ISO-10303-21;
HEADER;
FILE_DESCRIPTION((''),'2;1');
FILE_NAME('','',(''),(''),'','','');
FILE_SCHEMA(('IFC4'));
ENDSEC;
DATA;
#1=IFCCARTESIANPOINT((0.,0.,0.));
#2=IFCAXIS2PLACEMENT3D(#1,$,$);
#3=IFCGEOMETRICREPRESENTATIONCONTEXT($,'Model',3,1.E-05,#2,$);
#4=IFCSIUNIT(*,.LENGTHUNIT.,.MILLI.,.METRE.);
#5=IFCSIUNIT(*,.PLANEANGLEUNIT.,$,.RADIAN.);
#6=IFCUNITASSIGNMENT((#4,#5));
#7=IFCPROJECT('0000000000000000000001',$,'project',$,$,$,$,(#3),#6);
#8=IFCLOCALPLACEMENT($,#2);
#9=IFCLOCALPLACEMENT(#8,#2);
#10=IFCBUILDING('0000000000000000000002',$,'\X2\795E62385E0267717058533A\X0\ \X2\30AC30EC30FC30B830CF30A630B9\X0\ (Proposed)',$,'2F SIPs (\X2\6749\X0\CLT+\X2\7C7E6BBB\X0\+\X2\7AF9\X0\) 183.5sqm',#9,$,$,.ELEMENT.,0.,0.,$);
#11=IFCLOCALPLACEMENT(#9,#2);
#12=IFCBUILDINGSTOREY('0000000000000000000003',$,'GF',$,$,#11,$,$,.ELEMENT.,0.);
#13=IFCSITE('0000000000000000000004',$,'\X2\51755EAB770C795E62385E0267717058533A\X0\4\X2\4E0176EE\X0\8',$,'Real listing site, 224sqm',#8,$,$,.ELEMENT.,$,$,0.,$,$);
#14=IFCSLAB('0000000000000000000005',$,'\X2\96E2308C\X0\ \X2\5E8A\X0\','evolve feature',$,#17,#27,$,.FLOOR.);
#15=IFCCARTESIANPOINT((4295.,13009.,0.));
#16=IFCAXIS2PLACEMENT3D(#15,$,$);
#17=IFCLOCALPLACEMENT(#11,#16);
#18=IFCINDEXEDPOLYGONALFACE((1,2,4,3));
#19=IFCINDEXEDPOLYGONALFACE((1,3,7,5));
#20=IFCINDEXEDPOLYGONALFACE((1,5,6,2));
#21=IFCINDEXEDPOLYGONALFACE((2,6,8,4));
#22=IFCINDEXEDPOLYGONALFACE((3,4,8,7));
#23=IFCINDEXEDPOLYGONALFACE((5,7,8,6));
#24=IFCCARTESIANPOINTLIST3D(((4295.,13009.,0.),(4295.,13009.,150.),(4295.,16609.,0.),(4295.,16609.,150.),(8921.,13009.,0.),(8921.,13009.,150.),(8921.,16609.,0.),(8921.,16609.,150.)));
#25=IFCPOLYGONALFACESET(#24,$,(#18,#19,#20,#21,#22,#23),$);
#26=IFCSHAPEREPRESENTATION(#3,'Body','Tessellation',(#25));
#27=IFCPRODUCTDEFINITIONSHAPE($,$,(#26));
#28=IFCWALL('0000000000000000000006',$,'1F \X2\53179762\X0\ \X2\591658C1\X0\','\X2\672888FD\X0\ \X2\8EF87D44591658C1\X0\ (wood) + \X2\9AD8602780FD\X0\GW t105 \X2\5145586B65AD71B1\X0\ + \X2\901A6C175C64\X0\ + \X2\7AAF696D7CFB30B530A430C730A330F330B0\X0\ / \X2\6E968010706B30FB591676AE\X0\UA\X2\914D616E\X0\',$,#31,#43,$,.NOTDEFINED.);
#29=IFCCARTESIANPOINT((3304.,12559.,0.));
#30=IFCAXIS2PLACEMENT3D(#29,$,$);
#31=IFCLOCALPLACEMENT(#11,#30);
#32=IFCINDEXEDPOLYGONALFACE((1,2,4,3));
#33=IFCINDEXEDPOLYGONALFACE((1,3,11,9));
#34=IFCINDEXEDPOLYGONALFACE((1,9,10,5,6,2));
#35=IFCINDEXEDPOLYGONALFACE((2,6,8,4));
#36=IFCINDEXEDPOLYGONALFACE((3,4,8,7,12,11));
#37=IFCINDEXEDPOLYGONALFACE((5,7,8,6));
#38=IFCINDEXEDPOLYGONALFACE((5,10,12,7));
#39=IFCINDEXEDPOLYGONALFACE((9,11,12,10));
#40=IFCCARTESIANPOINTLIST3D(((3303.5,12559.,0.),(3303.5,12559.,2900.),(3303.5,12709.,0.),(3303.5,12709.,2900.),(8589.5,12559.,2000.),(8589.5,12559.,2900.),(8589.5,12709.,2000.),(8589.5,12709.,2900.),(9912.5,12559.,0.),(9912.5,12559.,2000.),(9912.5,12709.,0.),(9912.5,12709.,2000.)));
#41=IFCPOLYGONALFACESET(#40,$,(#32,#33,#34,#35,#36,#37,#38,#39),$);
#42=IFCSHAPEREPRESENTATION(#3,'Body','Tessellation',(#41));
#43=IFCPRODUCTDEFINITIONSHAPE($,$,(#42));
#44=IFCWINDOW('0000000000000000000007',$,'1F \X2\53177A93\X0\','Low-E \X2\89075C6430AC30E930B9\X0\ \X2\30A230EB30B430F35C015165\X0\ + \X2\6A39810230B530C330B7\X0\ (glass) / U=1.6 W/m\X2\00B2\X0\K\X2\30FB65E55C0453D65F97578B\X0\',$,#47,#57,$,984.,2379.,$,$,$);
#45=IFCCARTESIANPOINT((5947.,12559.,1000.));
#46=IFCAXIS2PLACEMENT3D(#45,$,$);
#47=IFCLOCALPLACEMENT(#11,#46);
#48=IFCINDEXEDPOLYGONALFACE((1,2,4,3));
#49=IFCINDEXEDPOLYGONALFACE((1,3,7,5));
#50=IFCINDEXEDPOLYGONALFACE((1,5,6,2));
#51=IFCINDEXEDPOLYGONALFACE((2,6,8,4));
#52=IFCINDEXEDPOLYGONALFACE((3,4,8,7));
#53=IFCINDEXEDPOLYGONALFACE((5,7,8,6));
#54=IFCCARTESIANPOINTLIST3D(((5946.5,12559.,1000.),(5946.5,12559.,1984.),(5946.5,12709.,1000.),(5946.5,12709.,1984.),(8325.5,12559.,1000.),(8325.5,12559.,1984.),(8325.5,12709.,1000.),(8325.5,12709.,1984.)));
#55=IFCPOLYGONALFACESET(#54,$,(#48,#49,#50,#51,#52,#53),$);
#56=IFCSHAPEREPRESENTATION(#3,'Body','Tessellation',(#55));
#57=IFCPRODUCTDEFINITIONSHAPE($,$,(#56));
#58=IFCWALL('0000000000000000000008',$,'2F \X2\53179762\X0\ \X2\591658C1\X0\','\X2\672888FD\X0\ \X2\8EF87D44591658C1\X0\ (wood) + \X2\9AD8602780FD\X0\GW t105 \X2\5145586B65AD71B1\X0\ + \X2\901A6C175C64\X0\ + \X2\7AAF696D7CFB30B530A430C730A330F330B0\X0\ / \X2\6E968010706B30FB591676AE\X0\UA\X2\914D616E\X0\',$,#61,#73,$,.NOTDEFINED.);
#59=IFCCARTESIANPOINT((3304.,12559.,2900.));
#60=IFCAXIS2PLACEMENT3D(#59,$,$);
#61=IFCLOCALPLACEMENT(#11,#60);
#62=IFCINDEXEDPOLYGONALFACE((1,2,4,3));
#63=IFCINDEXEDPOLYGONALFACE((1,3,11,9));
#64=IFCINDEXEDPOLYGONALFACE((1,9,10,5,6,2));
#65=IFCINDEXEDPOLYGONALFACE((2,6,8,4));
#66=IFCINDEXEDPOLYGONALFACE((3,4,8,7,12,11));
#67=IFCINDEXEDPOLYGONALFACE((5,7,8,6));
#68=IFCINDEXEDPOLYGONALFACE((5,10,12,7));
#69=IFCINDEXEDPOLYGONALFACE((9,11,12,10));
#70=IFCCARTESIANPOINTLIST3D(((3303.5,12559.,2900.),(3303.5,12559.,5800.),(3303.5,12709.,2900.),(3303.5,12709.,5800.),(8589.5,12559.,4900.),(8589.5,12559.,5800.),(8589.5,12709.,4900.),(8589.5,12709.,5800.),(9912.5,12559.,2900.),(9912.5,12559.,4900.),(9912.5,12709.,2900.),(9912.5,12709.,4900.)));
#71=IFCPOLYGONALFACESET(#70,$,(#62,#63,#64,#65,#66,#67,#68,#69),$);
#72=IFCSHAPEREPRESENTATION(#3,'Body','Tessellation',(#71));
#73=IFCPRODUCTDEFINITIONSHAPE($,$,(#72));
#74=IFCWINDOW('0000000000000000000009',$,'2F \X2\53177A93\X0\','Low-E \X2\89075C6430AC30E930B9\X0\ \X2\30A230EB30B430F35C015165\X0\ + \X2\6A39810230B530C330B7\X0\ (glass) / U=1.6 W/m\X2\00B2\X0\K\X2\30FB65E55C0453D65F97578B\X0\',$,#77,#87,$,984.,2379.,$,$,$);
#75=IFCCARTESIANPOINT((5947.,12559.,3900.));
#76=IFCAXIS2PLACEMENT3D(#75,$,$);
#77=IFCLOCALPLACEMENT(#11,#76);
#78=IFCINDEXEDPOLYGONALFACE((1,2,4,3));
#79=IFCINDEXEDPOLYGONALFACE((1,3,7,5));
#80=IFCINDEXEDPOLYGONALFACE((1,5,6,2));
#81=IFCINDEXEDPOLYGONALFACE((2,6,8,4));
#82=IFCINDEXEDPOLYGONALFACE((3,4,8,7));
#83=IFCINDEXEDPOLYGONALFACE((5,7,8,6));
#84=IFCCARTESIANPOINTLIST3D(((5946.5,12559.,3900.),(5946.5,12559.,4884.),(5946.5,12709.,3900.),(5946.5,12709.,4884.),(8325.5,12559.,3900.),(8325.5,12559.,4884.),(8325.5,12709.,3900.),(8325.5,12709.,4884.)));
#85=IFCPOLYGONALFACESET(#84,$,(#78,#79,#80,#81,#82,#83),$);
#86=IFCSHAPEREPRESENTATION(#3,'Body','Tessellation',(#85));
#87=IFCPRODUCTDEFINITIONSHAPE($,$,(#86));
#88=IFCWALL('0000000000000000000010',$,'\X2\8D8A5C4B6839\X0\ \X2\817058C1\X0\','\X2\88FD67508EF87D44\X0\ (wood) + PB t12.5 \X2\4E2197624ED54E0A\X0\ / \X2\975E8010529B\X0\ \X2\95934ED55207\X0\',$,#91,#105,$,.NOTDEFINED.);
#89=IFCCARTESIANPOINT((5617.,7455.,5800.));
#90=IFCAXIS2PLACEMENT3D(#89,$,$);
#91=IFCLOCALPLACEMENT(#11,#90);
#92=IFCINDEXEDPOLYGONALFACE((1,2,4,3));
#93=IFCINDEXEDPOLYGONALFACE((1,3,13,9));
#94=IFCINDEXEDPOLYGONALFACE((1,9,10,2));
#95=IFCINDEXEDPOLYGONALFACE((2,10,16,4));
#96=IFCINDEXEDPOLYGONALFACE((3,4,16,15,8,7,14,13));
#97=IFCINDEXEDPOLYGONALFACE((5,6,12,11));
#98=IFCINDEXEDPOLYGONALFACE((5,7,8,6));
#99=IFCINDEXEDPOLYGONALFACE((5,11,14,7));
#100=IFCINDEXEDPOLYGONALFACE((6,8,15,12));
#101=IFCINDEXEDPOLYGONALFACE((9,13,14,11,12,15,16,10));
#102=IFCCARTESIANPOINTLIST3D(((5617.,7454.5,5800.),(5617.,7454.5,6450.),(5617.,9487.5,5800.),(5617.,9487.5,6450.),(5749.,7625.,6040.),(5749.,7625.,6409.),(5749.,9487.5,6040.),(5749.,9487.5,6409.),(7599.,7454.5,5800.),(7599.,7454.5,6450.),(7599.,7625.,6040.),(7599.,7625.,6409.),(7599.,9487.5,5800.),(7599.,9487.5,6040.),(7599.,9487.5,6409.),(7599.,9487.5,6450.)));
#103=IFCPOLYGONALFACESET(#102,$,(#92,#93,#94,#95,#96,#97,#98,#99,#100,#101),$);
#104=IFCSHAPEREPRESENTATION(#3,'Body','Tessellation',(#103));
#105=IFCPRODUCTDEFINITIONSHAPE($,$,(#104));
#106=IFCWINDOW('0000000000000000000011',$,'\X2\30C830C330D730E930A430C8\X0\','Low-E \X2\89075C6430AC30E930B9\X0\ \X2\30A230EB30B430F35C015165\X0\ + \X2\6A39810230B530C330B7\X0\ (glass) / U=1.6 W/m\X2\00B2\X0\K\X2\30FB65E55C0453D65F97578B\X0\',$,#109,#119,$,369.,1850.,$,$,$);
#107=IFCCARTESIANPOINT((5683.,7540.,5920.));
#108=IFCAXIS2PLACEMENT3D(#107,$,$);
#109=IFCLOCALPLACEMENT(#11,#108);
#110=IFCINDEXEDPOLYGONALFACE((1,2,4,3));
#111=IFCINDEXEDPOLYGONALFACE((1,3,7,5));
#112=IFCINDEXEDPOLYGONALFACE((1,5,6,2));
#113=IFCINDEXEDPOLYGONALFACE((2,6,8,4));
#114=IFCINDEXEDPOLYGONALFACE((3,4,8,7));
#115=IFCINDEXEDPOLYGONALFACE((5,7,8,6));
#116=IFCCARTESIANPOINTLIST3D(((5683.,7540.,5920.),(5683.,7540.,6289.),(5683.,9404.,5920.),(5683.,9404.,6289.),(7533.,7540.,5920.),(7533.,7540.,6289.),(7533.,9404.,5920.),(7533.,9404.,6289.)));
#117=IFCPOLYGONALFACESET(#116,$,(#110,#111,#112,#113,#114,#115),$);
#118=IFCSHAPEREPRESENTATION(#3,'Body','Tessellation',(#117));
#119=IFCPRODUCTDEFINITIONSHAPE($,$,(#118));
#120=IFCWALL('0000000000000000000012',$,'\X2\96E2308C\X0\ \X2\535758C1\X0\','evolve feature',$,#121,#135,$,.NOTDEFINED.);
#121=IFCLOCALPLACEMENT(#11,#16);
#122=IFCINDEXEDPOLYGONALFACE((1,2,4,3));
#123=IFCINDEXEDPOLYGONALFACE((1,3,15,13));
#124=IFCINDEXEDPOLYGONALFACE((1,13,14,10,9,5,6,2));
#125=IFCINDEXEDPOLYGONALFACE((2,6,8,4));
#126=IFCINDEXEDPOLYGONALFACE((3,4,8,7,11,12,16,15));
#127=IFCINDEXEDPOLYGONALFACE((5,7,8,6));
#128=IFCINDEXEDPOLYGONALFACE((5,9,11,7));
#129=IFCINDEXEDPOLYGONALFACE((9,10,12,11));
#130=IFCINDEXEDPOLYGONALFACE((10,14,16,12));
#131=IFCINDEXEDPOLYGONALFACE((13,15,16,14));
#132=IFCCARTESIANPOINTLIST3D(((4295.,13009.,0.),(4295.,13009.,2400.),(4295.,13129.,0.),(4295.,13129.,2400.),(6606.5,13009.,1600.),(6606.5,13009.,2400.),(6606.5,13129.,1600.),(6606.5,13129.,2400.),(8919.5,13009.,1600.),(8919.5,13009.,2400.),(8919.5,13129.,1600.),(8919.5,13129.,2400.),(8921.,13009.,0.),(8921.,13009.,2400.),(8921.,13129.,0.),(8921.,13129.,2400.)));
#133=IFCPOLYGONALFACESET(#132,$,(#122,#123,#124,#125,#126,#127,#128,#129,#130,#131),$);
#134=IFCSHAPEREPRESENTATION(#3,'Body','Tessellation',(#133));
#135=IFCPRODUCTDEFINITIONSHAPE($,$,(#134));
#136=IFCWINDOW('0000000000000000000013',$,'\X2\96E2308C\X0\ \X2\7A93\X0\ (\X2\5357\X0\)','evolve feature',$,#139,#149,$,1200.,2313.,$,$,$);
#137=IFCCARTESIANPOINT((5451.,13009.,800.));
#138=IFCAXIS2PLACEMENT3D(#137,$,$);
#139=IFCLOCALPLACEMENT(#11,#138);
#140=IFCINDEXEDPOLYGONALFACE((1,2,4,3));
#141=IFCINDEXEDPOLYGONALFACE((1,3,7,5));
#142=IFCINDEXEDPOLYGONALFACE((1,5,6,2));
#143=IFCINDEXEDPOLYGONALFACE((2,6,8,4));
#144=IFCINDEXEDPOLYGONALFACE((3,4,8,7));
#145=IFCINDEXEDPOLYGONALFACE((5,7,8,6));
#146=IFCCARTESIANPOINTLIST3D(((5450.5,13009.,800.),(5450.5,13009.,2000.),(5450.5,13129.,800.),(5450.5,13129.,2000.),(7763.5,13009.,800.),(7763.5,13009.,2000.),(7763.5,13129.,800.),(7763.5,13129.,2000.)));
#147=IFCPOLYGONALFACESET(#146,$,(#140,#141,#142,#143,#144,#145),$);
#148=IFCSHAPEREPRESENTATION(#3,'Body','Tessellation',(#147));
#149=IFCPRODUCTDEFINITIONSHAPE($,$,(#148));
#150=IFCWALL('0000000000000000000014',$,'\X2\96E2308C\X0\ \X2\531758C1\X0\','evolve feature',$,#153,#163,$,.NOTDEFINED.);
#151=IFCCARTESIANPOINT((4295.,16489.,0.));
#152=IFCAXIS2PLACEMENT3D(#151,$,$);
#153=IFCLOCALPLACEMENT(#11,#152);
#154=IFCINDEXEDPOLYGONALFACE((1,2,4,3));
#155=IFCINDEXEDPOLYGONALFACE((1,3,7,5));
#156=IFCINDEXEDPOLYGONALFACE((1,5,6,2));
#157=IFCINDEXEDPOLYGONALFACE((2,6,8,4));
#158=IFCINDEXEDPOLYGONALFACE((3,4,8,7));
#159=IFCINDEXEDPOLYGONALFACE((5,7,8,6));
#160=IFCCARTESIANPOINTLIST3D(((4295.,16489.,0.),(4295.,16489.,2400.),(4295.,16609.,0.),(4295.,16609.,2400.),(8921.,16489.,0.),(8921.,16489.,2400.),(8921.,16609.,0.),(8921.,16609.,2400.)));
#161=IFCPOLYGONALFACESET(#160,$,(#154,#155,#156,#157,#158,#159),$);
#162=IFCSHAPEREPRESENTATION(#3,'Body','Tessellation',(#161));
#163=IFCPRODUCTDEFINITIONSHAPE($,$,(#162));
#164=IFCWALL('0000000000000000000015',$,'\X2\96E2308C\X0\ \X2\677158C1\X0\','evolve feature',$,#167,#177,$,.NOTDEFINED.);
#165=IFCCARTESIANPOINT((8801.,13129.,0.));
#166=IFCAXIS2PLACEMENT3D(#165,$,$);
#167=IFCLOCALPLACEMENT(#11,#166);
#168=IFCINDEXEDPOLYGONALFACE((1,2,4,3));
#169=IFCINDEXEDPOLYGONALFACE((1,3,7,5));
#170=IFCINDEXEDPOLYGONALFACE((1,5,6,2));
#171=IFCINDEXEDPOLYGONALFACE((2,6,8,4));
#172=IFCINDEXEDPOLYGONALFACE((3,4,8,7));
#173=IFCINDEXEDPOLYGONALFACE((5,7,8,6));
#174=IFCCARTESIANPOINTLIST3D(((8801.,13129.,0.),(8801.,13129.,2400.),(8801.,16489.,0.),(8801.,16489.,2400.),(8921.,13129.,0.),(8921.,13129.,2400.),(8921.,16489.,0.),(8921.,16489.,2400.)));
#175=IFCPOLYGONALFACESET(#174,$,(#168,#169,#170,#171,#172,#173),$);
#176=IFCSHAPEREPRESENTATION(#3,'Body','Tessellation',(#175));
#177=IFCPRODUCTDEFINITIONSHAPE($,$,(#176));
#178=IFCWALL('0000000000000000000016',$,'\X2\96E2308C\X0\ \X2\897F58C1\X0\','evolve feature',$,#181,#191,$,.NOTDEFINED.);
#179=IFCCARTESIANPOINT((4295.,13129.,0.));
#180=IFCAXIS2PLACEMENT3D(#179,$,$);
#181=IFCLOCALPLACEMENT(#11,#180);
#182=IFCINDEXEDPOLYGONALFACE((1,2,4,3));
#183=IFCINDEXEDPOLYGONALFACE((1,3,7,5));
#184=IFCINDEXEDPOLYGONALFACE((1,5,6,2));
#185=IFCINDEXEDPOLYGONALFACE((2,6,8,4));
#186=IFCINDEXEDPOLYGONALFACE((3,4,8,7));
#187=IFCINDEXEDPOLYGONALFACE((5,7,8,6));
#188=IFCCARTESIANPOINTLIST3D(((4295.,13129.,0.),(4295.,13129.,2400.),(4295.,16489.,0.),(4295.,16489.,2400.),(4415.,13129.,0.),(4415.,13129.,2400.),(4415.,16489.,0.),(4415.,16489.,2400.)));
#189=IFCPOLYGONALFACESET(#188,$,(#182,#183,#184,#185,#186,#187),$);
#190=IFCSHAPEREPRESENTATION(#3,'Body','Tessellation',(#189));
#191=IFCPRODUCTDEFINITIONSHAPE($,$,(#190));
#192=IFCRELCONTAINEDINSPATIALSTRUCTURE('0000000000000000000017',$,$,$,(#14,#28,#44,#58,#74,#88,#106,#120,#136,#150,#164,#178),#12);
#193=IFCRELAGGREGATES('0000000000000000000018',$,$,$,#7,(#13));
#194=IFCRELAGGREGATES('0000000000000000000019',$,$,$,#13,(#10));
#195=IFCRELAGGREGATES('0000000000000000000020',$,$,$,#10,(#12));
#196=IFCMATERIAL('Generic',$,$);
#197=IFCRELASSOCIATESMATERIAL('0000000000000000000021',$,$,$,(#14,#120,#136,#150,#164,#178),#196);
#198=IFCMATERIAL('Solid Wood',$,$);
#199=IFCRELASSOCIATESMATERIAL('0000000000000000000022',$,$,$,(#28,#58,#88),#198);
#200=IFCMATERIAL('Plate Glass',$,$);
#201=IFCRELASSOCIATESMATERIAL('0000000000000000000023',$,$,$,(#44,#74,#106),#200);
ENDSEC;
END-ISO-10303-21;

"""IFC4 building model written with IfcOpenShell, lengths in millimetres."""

from ifc_helpers import new_model, si_unit, frame, frame_2d, origin, place, context, project, spatial, rectangle, extrude, material, element, fill, save


model = new_model("IFC4")

# Units and contexts
model_context = context("Model", 3, precision=1e-05, world=origin())
ifc_project = project(units=[si_unit("LENGTHUNIT", "METRE", prefix="MILLI"), si_unit("PLANEANGLEUNIT", "RADIAN")], contexts=[model_context])

# Site, building, storey
site_placement = place(None, origin())
site = spatial("IfcSite", under=ifc_project, at=site_placement, Name="兵庫県神戸市東灘区4丁目8", ObjectType="Real listing site, 224sqm", CompositionType="ELEMENT", RefElevation=0.0)
building_placement = place(site_placement, origin())
building = spatial("IfcBuilding", under=site, at=building_placement, Name="神戸市東灘区 ガレージハウス (Proposed)", ObjectType="2F SIPs (杉CLT+籾殻+竹) 183.5sqm", CompositionType="ELEMENT", ElevationOfRefHeight=0.0, ElevationOfTerrain=0.0)
storey_placement = place(building_placement, origin())
storey = spatial("IfcBuildingStorey", under=building, at=storey_placement, Name="GF", CompositionType="ELEMENT", Elevation=0.0)

# Slab
ifc_material_1 = material(Name="Generic")
slab_placement = place(storey_placement, frame((4295.0, 13009.0, 0.0)))
element("IfcSlab", 1, at=slab_placement, inside=storey, material=ifc_material_1, Name="離れ 床", Description="evolve feature", PredefinedType="FLOOR", context=model_context, shape_type="SweptSolid", body=[
    extrude(rectangle(XDim=4626.0, YDim=3600.0, at=frame_2d((2313.0, 1800.0))), frame((4295.0, 13009.0, 0.0)), (0.0, 0.0, 1.0), 150.0),
])

# Wall, opening, window
ifc_material_2 = material(Name="Solid Wood")
wall_1_placement = place(storey_placement, frame((3304.0, 12559.0, 0.0)))
wall_1 = element("IfcWall", 2, at=wall_1_placement, inside=storey, material=ifc_material_2, Name="1F 北面 外壁", Description="木製 軸組外壁 (wood) + 高性能GW t105 充填断熱 + 通気層 + 窯業系サイディング / 準耐火・外皮UA配慮", PredefinedType="NOTDEFINED", context=model_context, shape_type="SweptSolid", body=[
    extrude(rectangle(XDim=6609.0, YDim=150.0, at=frame_2d((3304.0, 75.0))), frame((3304.0, 12559.0, 0.0)), (0.0, 0.0, 1.0), 2900.0),
])
opening_1_placement = place(storey_placement, frame((5947.0, 12559.0, 1000.0)))
opening_1 = element("IfcOpeningElement", 3, at=opening_1_placement, cuts=wall_1, PredefinedType="NOTDEFINED", context=model_context, shape_type="SweptSolid", body=[
    extrude(rectangle(XDim=2379.0, YDim=150.0, at=frame_2d((1189.0, 75.0))), frame((5947.0, 12559.0, 1000.0)), (0.0, 0.0, 1.0), 984.0),
])
ifc_material_3 = material(Name="Plate Glass")
window_1_placement = place(storey_placement, frame((5947.0, 12559.0, 1000.0)))
window_1 = element("IfcWindow", 4, at=window_1_placement, inside=storey, material=ifc_material_3, Name="1F 北窓", Description="Low-E 複層ガラス アルゴン封入 + 樹脂サッシ (glass) / U=1.6 W/m²K・日射取得型", OverallHeight=984.0, OverallWidth=2379.0, context=model_context, shape_type="SweptSolid", body=[
    extrude(rectangle(XDim=2379.0, YDim=150.0, at=frame_2d((1189.0, 75.0))), frame((5947.0, 12559.0, 1000.0)), (0.0, 0.0, 1.0), 984.0),
])
fill(opening_1, window_1)

# Wall, opening, window
wall_2_placement = place(storey_placement, frame((3304.0, 12559.0, 2900.0)))
wall_2 = element("IfcWall", 5, at=wall_2_placement, inside=storey, material=ifc_material_2, Name="2F 北面 外壁", Description="木製 軸組外壁 (wood) + 高性能GW t105 充填断熱 + 通気層 + 窯業系サイディング / 準耐火・外皮UA配慮", PredefinedType="NOTDEFINED", context=model_context, shape_type="SweptSolid", body=[
    extrude(rectangle(XDim=6609.0, YDim=150.0, at=frame_2d((3304.0, 75.0))), frame((3304.0, 12559.0, 2900.0)), (0.0, 0.0, 1.0), 2900.0),
])
opening_2_placement = place(storey_placement, frame((5947.0, 12559.0, 3900.0)))
opening_2 = element("IfcOpeningElement", 6, at=opening_2_placement, cuts=wall_2, PredefinedType="NOTDEFINED", context=model_context, shape_type="SweptSolid", body=[
    extrude(rectangle(XDim=2379.0, YDim=150.0, at=frame_2d((1189.0, 75.0))), frame((5947.0, 12559.0, 3900.0)), (0.0, 0.0, 1.0), 984.0),
])
window_2_placement = place(storey_placement, frame((5947.0, 12559.0, 3900.0)))
window_2 = element("IfcWindow", 7, at=window_2_placement, inside=storey, material=ifc_material_3, Name="2F 北窓", Description="Low-E 複層ガラス アルゴン封入 + 樹脂サッシ (glass) / U=1.6 W/m²K・日射取得型", OverallHeight=984.0, OverallWidth=2379.0, context=model_context, shape_type="SweptSolid", body=[
    extrude(rectangle(XDim=2379.0, YDim=150.0, at=frame_2d((1189.0, 75.0))), frame((5947.0, 12559.0, 3900.0)), (0.0, 0.0, 1.0), 984.0),
])
fill(opening_2, window_2)

# Walls, openings, windows
wall_3_placement = place(storey_placement, frame((5617.0, 7455.0, 5800.0)))
wall_3 = element("IfcWall", 8, at=wall_3_placement, inside=storey, material=ifc_material_2, Name="越屋根 腰壁", Description="製材軸組 (wood) + PB t12.5 両面仕上 / 非耐力 間仕切", PredefinedType="NOTDEFINED", context=model_context, shape_type="SweptSolid", body=[
    extrude(rectangle(XDim=1982.0, YDim=2033.0, at=frame_2d((991.0, 1016.0))), frame((5617.0, 7455.0, 5800.0)), (0.0, 0.0, 1.0), 650.0),
])
opening_3_placement = place(storey_placement, frame((5683.0, 7540.0, 5920.0)))
opening_3 = element("IfcOpeningElement", 9, at=opening_3_placement, cuts=wall_3, PredefinedType="NOTDEFINED", context=model_context, shape_type="SweptSolid", body=[
    extrude(rectangle(XDim=1850.0, YDim=1864.0, at=frame_2d((925.0, 932.0))), frame((5683.0, 7540.0, 5920.0)), (0.0, 0.0, 1.0), 369.0),
])
window_3_placement = place(storey_placement, frame((5683.0, 7540.0, 5920.0)))
window_3 = element("IfcWindow", 10, at=window_3_placement, inside=storey, material=ifc_material_3, Name="トップライト", Description="Low-E 複層ガラス アルゴン封入 + 樹脂サッシ (glass) / U=1.6 W/m²K・日射取得型", OverallHeight=369.0, OverallWidth=1850.0, context=model_context, shape_type="SweptSolid", body=[
    extrude(rectangle(XDim=1850.0, YDim=1864.0, at=frame_2d((925.0, 932.0))), frame((5683.0, 7540.0, 5920.0)), (0.0, 0.0, 1.0), 369.0),
])
fill(opening_3, window_3)
wall_4_placement = place(storey_placement, frame((4295.0, 13009.0, 0.0)))
wall_4 = element("IfcWall", 11, at=wall_4_placement, inside=storey, material=ifc_material_1, Name="離れ 南壁", Description="evolve feature", PredefinedType="NOTDEFINED", context=model_context, shape_type="SweptSolid", body=[
    extrude(rectangle(XDim=4626.0, YDim=120.0, at=frame_2d((2313.0, 60.0))), frame((4295.0, 13009.0, 0.0)), (0.0, 0.0, 1.0), 2400.0),
])
opening_4_placement = place(storey_placement, frame((5451.0, 13009.0, 800.0)))
opening_4 = element("IfcOpeningElement", 12, at=opening_4_placement, cuts=wall_4, PredefinedType="NOTDEFINED", context=model_context, shape_type="SweptSolid", body=[
    extrude(rectangle(XDim=2313.0, YDim=120.0, at=frame_2d((1156.0, 60.0))), frame((5451.0, 13009.0, 800.0)), (0.0, 0.0, 1.0), 1200.0),
])
window_4_placement = place(storey_placement, frame((5451.0, 13009.0, 800.0)))
window_4 = element("IfcWindow", 13, at=window_4_placement, inside=storey, material=ifc_material_1, Name="離れ 窓 (南)", Description="evolve feature", OverallHeight=1200.0, OverallWidth=2313.0, context=model_context, shape_type="SweptSolid", body=[
    extrude(rectangle(XDim=2313.0, YDim=120.0, at=frame_2d((1156.0, 60.0))), frame((5451.0, 13009.0, 800.0)), (0.0, 0.0, 1.0), 1200.0),
])
fill(opening_4, window_4)

# Walls
wall_5_placement = place(storey_placement, frame((4295.0, 16489.0, 0.0)))
element("IfcWall", 14, at=wall_5_placement, inside=storey, material=ifc_material_1, Name="離れ 北壁", Description="evolve feature", PredefinedType="NOTDEFINED", context=model_context, shape_type="SweptSolid", body=[
    extrude(rectangle(XDim=4626.0, YDim=120.0, at=frame_2d((2313.0, 60.0))), frame((4295.0, 16489.0, 0.0)), (0.0, 0.0, 1.0), 2400.0),
])
wall_6_placement = place(storey_placement, frame((8801.0, 13129.0, 0.0)))
element("IfcWall", 15, at=wall_6_placement, inside=storey, material=ifc_material_1, Name="離れ 東壁", Description="evolve feature", PredefinedType="NOTDEFINED", context=model_context, shape_type="SweptSolid", body=[
    extrude(rectangle(XDim=120.0, YDim=3360.0, at=frame_2d((60.0, 1680.0))), frame((8801.0, 13129.0, 0.0)), (0.0, 0.0, 1.0), 2400.0),
])
wall_7_placement = place(storey_placement, frame((4295.0, 13129.0, 0.0)))
element("IfcWall", 16, at=wall_7_placement, inside=storey, material=ifc_material_1, Name="離れ 西壁", Description="evolve feature", PredefinedType="NOTDEFINED", context=model_context, shape_type="SweptSolid", body=[
    extrude(rectangle(XDim=120.0, YDim=3360.0, at=frame_2d((60.0, 1680.0))), frame((4295.0, 13129.0, 0.0)), (0.0, 0.0, 1.0), 2400.0),
])

save(model, "model.ifc")
